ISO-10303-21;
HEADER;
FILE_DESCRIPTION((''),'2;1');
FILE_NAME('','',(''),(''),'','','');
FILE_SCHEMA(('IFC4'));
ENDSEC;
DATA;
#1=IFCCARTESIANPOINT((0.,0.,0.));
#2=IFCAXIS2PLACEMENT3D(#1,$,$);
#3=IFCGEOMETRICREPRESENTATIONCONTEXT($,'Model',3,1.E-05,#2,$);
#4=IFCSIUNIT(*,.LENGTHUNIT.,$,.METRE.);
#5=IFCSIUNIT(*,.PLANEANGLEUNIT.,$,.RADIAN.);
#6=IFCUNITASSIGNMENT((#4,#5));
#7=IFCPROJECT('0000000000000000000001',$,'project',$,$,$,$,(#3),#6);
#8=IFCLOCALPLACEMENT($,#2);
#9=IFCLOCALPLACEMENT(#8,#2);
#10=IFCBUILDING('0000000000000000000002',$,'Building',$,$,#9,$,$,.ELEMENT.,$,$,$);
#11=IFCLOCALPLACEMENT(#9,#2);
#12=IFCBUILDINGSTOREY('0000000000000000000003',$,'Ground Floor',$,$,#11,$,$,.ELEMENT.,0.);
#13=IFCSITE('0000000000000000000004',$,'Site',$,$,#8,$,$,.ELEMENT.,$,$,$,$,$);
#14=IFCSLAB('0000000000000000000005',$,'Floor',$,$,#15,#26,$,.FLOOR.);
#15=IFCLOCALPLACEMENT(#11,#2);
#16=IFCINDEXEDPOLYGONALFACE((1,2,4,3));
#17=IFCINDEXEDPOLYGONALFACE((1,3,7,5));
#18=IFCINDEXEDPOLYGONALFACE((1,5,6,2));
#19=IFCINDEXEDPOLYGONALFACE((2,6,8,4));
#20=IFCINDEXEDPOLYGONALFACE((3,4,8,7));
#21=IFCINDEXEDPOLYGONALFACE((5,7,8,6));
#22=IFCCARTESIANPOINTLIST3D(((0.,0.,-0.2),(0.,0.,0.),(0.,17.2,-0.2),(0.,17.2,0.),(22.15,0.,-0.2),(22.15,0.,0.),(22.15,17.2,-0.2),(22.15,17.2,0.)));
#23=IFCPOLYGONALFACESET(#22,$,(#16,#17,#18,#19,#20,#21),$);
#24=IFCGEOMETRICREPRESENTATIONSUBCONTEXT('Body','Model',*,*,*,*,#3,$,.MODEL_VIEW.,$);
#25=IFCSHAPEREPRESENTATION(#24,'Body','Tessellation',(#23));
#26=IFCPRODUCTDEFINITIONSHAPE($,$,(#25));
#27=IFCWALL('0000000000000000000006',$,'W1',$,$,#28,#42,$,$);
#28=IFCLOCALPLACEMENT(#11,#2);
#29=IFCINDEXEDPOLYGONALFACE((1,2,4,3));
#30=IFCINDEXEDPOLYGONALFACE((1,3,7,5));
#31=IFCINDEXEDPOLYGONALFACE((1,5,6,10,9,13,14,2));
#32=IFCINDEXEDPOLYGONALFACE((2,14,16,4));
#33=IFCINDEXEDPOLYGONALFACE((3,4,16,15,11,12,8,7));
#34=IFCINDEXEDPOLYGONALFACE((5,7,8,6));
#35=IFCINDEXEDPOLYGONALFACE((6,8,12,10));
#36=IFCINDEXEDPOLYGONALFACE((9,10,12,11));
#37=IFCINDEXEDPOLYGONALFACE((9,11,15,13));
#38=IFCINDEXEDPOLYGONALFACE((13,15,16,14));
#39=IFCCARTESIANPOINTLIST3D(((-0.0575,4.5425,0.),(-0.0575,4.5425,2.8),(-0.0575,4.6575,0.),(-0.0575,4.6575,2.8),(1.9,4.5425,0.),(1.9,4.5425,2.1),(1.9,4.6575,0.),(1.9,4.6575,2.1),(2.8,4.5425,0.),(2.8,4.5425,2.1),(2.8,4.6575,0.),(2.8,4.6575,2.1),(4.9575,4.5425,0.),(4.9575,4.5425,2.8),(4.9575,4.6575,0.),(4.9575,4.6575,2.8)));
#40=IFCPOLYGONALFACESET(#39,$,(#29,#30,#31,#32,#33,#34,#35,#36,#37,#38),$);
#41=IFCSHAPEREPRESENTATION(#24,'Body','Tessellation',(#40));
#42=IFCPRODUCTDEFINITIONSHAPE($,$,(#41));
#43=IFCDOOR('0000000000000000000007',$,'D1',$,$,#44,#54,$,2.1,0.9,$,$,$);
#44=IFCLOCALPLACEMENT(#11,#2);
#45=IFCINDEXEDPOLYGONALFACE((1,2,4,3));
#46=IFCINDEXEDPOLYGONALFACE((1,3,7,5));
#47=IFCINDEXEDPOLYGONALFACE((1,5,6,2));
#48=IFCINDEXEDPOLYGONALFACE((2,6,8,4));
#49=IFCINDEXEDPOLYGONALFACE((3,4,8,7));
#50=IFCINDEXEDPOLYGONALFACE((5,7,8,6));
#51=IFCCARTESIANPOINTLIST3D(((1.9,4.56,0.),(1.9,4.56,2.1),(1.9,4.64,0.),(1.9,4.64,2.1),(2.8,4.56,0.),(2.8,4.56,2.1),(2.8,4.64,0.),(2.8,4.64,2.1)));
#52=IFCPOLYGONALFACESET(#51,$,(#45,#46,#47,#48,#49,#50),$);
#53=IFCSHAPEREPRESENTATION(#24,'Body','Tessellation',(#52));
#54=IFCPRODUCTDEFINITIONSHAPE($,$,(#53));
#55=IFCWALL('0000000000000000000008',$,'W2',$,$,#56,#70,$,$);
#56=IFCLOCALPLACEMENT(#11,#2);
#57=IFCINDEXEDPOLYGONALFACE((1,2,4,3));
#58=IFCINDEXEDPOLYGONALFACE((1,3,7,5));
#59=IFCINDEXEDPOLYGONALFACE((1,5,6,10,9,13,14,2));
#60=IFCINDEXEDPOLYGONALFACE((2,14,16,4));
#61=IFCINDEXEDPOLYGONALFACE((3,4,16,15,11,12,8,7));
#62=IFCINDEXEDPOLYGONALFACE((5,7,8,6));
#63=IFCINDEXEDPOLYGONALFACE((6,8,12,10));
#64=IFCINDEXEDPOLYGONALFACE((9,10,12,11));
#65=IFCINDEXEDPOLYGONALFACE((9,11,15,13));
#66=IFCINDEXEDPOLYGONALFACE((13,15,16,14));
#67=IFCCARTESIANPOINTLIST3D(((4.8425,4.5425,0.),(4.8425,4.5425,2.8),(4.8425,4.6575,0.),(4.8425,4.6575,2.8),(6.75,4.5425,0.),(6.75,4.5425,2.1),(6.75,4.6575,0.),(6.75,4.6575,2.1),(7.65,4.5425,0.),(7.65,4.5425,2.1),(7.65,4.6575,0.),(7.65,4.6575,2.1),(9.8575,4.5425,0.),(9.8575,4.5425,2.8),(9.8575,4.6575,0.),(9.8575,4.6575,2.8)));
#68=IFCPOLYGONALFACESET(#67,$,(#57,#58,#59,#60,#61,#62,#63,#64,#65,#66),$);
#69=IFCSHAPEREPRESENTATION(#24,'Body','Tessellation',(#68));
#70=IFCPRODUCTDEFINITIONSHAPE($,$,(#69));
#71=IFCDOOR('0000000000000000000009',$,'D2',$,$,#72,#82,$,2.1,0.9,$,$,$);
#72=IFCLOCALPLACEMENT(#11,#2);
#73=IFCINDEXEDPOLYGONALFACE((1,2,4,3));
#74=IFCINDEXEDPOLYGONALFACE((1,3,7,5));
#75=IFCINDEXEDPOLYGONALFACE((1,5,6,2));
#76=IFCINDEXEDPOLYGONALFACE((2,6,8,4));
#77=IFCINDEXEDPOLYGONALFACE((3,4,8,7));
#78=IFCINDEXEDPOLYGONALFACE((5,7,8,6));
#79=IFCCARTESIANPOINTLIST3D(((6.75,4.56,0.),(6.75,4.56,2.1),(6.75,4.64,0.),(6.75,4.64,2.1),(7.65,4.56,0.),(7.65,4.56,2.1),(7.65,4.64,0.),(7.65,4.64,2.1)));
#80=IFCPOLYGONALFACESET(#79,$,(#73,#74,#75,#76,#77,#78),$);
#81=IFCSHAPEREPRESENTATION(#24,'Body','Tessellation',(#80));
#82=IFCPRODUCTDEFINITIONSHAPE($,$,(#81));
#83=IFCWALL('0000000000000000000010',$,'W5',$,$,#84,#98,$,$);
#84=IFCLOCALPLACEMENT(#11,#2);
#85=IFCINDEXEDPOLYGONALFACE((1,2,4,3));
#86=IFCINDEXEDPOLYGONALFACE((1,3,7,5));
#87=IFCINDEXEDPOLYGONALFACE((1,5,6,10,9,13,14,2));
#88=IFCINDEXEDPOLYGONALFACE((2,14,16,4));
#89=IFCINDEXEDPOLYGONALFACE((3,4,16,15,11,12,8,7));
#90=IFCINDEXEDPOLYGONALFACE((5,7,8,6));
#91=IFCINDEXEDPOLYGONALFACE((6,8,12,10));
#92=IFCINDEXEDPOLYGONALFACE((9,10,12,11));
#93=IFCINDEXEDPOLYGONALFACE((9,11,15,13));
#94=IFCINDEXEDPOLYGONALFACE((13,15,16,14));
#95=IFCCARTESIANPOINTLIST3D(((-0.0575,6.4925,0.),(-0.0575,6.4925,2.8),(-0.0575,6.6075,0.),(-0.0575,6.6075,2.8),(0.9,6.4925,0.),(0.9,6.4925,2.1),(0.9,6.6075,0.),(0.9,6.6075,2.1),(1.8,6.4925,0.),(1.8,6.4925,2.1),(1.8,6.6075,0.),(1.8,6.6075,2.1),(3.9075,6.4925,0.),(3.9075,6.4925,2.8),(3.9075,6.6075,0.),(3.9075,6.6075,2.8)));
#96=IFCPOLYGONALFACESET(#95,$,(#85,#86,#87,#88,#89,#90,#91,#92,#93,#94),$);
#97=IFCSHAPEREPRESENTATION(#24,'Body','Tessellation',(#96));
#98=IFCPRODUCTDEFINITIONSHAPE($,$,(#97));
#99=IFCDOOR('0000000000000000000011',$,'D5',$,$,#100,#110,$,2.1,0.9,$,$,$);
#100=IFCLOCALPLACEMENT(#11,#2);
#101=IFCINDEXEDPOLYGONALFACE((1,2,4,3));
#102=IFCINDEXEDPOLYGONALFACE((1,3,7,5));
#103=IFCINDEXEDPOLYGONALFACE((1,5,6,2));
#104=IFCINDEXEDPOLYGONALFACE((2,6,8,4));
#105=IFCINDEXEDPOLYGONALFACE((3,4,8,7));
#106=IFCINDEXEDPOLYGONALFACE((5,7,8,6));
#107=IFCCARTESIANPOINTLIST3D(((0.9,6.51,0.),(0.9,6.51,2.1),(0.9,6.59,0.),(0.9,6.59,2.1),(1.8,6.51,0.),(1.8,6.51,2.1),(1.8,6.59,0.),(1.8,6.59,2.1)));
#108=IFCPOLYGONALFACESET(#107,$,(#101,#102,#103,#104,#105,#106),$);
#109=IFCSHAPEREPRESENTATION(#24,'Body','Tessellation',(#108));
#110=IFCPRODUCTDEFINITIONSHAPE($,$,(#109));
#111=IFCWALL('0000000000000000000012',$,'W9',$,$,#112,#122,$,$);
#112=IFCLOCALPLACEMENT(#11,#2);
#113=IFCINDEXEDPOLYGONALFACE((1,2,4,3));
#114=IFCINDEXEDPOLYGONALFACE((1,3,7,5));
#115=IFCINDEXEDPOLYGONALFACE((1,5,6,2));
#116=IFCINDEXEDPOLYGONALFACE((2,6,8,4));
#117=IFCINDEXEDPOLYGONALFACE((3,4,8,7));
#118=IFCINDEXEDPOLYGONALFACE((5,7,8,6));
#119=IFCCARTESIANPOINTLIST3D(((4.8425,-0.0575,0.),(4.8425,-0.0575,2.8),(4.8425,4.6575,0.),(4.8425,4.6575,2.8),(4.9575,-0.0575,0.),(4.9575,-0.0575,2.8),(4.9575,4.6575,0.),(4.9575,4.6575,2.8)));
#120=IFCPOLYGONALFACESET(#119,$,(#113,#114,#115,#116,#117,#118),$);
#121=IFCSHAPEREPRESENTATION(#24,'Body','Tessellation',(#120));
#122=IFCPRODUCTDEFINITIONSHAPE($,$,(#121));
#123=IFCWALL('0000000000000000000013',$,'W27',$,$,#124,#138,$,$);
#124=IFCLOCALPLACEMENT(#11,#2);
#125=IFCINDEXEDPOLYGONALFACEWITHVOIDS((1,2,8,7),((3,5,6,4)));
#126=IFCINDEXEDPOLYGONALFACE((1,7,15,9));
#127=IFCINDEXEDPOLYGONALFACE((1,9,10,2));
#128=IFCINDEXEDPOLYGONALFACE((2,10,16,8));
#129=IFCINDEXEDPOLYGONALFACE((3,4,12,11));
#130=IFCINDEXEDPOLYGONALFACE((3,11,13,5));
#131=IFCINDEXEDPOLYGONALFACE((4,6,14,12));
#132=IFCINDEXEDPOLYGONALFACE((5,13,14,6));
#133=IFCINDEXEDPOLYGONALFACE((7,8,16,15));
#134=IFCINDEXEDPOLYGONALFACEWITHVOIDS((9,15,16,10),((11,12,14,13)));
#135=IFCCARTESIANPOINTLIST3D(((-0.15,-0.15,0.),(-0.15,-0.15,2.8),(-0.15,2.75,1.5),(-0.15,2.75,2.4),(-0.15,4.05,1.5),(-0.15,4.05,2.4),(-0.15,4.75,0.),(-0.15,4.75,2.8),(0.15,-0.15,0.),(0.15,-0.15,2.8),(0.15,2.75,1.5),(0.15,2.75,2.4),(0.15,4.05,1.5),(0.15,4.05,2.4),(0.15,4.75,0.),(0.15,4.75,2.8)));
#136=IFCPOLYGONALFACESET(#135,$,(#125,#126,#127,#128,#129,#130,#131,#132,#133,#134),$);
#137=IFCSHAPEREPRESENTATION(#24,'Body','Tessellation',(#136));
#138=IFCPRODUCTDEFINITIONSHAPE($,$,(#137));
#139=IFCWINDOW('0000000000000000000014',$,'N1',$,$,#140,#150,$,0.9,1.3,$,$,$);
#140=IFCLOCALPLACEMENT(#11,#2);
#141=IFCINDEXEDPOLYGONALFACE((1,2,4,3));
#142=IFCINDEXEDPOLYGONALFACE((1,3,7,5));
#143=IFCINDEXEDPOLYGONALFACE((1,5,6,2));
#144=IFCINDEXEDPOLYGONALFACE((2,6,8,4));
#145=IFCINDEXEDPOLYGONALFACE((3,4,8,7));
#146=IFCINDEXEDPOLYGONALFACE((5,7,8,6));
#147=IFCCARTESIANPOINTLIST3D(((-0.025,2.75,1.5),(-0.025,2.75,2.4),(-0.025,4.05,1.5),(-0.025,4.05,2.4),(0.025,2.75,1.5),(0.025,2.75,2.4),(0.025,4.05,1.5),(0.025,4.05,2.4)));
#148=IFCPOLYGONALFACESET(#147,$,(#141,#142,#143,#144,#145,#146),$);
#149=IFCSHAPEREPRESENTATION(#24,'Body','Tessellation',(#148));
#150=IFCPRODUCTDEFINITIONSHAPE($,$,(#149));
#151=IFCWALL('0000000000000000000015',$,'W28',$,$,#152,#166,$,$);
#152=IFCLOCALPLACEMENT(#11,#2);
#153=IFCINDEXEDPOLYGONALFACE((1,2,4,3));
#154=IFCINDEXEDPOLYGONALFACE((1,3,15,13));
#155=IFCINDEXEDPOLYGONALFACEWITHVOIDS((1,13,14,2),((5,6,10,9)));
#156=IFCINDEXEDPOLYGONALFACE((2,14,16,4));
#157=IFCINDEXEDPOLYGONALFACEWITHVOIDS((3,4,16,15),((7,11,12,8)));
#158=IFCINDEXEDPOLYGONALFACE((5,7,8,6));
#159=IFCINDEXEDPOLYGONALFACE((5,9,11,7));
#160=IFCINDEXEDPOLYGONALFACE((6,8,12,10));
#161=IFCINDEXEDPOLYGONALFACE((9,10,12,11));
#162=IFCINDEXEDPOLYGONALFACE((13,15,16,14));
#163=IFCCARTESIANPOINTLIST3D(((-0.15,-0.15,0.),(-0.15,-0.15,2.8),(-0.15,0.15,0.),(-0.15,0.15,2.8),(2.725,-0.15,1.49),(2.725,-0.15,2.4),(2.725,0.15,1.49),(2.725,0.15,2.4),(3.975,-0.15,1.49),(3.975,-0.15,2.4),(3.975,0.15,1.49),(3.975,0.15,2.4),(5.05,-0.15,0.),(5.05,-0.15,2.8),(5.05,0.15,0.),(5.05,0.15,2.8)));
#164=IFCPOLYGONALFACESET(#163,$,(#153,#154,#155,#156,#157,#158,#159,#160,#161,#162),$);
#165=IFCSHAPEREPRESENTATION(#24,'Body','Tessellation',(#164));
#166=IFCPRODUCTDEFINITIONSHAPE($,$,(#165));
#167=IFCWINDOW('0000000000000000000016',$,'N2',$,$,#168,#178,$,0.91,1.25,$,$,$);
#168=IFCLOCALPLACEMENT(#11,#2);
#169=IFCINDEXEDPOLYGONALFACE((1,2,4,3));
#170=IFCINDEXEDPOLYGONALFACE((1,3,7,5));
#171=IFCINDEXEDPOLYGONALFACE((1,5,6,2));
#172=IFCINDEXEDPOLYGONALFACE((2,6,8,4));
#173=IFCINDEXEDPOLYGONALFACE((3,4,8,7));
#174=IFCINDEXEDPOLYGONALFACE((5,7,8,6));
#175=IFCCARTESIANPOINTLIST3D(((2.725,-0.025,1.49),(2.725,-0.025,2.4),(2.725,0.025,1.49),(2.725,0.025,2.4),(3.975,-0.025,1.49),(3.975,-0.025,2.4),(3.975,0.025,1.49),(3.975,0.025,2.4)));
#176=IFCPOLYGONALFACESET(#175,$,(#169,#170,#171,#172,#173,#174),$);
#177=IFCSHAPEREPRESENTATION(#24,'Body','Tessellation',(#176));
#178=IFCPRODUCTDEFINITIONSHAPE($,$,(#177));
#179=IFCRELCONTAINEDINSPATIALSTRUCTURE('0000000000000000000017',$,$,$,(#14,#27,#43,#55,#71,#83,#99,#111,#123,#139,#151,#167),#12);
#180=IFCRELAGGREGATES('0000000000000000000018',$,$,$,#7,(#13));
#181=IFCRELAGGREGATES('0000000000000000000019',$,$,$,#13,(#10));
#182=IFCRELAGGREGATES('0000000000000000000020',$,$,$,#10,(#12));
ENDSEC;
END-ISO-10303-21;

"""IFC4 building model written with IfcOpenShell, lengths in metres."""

from ifc_helpers import new_model, si_unit, frame, frame_2d, origin, origin_2d, place, context, subcontext, project, spatial, polyline, rectangle, outline, extrude, element, fill, save


model = new_model("IFC4")

# Units and contexts
model_context = context("Model", 3, precision=1e-05, world=origin())
body_context = subcontext(model_context, "Body", "Model", "MODEL_VIEW")
ifc_project = project(units=[si_unit("LENGTHUNIT", "METRE"), si_unit("PLANEANGLEUNIT", "RADIAN")], contexts=[model_context])

# Site, building, storey
site_placement = place(None, origin())
site = spatial("IfcSite", under=ifc_project, at=site_placement, Name="Site", CompositionType="ELEMENT")
building_placement = place(site_placement, origin())
building = spatial("IfcBuilding", under=site, at=building_placement, Name="Building", CompositionType="ELEMENT")
storey_placement = place(building_placement, origin())
storey = spatial("IfcBuildingStorey", under=building, at=storey_placement, Name="Ground Floor", CompositionType="ELEMENT", Elevation=0.0)

# Slab
slab_placement = place(storey_placement, origin())
element("IfcSlab", 1, at=slab_placement, inside=storey, Name="Floor", PredefinedType="FLOOR", context=body_context, shape_type="SweptSolid", body=[
    extrude(outline(polyline([(0.0, 0.0), (22.15, 0.0), (22.15, 17.2), (0.0, 17.2), (0.0, 0.0)])), origin(), (0.0, 0.0, -1.0), 0.2),
])

# Walls, openings, doors
wall_1_placement = place(storey_placement, frame((0.0, 4.6, 0.0), x_axis=(1.0, 0.0, 0.0)))
wall_1 = element("IfcWall", 2, at=wall_1_placement, inside=storey, Name="W1", context=body_context, shape_type="SweptSolid", body=[
    extrude(rectangle(XDim=5.015, YDim=0.115, at=frame_2d((2.45, 0.0))), origin(), (0.0, 0.0, 1.0), 2.8),
])
opening_1_placement = place(wall_1_placement, frame((2.35, 0.0, 0.0)))
opening_1 = element("IfcOpeningElement", 3, at=opening_1_placement, cuts=wall_1, context=body_context, shape_type="SweptSolid", body=[
    extrude(rectangle(XDim=0.9, YDim=0.215, at=origin_2d()), origin(), (0.0, 0.0, 1.0), 2.1),
])
door_1_placement = place(opening_1_placement, origin())
door_1 = element("IfcDoor", 4, at=door_1_placement, inside=storey, Name="D1", OverallHeight=2.1, OverallWidth=0.9, context=body_context, shape_type="SweptSolid", body=[
    extrude(rectangle(XDim=0.9, YDim=0.08, at=origin_2d()), origin(), (0.0, 0.0, 1.0), 2.1),
])
fill(opening_1, door_1)
wall_2_placement = place(storey_placement, frame((4.9, 4.6, 0.0), x_axis=(1.0, 0.0, 0.0)))
wall_2 = element("IfcWall", 5, at=wall_2_placement, inside=storey, Name="W2", context=body_context, shape_type="SweptSolid", body=[
    extrude(rectangle(XDim=5.015, YDim=0.115, at=frame_2d((2.45, 0.0))), origin(), (0.0, 0.0, 1.0), 2.8),
])
opening_2_placement = place(wall_2_placement, frame((2.3, 0.0, 0.0)))
opening_2 = element("IfcOpeningElement", 6, at=opening_2_placement, cuts=wall_2, context=body_context, shape_type="SweptSolid", body=[
    extrude(rectangle(XDim=0.9, YDim=0.215, at=origin_2d()), origin(), (0.0, 0.0, 1.0), 2.1),
])
door_2_placement = place(opening_2_placement, origin())
door_2 = element("IfcDoor", 7, at=door_2_placement, inside=storey, Name="D2", OverallHeight=2.1, OverallWidth=0.9, context=body_context, shape_type="SweptSolid", body=[
    extrude(rectangle(XDim=0.9, YDim=0.08, at=origin_2d()), origin(), (0.0, 0.0, 1.0), 2.1),
])
fill(opening_2, door_2)
wall_3_placement = place(storey_placement, frame((0.0, 6.55, 0.0), x_axis=(1.0, 0.0, 0.0)))
wall_3 = element("IfcWall", 8, at=wall_3_placement, inside=storey, Name="W5", context=body_context, shape_type="SweptSolid", body=[
    extrude(rectangle(XDim=3.965, YDim=0.115, at=frame_2d((1.925, 0.0))), origin(), (0.0, 0.0, 1.0), 2.8),
])
opening_3_placement = place(wall_3_placement, frame((1.35, 0.0, 0.0)))
opening_3 = element("IfcOpeningElement", 9, at=opening_3_placement, cuts=wall_3, context=body_context, shape_type="SweptSolid", body=[
    extrude(rectangle(XDim=0.9, YDim=0.215, at=origin_2d()), origin(), (0.0, 0.0, 1.0), 2.1),
])
door_3_placement = place(opening_3_placement, origin())
door_3 = element("IfcDoor", 10, at=door_3_placement, inside=storey, Name="D5", OverallHeight=2.1, OverallWidth=0.9, context=body_context, shape_type="SweptSolid", body=[
    extrude(rectangle(XDim=0.9, YDim=0.08, at=origin_2d()), origin(), (0.0, 0.0, 1.0), 2.1),
])
fill(opening_3, door_3)

# Wall
wall_4_placement = place(storey_placement, frame((4.9, 0.0, 0.0), x_axis=(0.0, 1.0, 0.0)))
element("IfcWall", 11, at=wall_4_placement, inside=storey, Name="W9", context=body_context, shape_type="SweptSolid", body=[
    extrude(rectangle(XDim=4.715, YDim=0.115, at=frame_2d((2.3, 0.0))), origin(), (0.0, 0.0, 1.0), 2.8),
])

# Walls, openings, windows
wall_5_placement = place(storey_placement, frame((0.0, 0.0, 0.0), x_axis=(0.0, 1.0, 0.0)))
wall_5 = element("IfcWall", 12, at=wall_5_placement, inside=storey, Name="W27", context=body_context, shape_type="SweptSolid", body=[
    extrude(rectangle(XDim=4.9, YDim=0.3, at=frame_2d((2.3, 0.0))), origin(), (0.0, 0.0, 1.0), 2.8),
])
opening_4_placement = place(wall_5_placement, frame((3.4, 0.0, 1.5)))
opening_4 = element("IfcOpeningElement", 13, at=opening_4_placement, cuts=wall_5, context=body_context, shape_type="SweptSolid", body=[
    extrude(rectangle(XDim=1.3, YDim=0.4, at=origin_2d()), origin(), (0.0, 0.0, 1.0), 0.9),
])
window_1_placement = place(opening_4_placement, origin())
window_1 = element("IfcWindow", 14, at=window_1_placement, inside=storey, Name="N1", OverallHeight=0.9, OverallWidth=1.3, context=body_context, shape_type="SweptSolid", body=[
    extrude(rectangle(XDim=1.3, YDim=0.05, at=origin_2d()), origin(), (0.0, 0.0, 1.0), 0.9),
])
fill(opening_4, window_1)
wall_6_placement = place(storey_placement, frame((0.0, 0.0, 0.0), x_axis=(1.0, 0.0, 0.0)))
wall_6 = element("IfcWall", 15, at=wall_6_placement, inside=storey, Name="W28", context=body_context, shape_type="SweptSolid", body=[
    extrude(rectangle(XDim=5.2, YDim=0.3, at=frame_2d((2.45, 0.0))), origin(), (0.0, 0.0, 1.0), 2.8),
])
opening_5_placement = place(wall_6_placement, frame((3.35, 0.0, 1.49)))
opening_5 = element("IfcOpeningElement", 16, at=opening_5_placement, cuts=wall_6, context=body_context, shape_type="SweptSolid", body=[
    extrude(rectangle(XDim=1.25, YDim=0.4, at=origin_2d()), origin(), (0.0, 0.0, 1.0), 0.91),
])
window_2_placement = place(opening_5_placement, origin())
window_2 = element("IfcWindow", 17, at=window_2_placement, inside=storey, Name="N2", OverallHeight=0.91, OverallWidth=1.25, context=body_context, shape_type="SweptSolid", body=[
    extrude(rectangle(XDim=1.25, YDim=0.05, at=origin_2d()), origin(), (0.0, 0.0, 1.0), 0.91),
])
fill(opening_5, window_2)

save(model, "model.ifc")
